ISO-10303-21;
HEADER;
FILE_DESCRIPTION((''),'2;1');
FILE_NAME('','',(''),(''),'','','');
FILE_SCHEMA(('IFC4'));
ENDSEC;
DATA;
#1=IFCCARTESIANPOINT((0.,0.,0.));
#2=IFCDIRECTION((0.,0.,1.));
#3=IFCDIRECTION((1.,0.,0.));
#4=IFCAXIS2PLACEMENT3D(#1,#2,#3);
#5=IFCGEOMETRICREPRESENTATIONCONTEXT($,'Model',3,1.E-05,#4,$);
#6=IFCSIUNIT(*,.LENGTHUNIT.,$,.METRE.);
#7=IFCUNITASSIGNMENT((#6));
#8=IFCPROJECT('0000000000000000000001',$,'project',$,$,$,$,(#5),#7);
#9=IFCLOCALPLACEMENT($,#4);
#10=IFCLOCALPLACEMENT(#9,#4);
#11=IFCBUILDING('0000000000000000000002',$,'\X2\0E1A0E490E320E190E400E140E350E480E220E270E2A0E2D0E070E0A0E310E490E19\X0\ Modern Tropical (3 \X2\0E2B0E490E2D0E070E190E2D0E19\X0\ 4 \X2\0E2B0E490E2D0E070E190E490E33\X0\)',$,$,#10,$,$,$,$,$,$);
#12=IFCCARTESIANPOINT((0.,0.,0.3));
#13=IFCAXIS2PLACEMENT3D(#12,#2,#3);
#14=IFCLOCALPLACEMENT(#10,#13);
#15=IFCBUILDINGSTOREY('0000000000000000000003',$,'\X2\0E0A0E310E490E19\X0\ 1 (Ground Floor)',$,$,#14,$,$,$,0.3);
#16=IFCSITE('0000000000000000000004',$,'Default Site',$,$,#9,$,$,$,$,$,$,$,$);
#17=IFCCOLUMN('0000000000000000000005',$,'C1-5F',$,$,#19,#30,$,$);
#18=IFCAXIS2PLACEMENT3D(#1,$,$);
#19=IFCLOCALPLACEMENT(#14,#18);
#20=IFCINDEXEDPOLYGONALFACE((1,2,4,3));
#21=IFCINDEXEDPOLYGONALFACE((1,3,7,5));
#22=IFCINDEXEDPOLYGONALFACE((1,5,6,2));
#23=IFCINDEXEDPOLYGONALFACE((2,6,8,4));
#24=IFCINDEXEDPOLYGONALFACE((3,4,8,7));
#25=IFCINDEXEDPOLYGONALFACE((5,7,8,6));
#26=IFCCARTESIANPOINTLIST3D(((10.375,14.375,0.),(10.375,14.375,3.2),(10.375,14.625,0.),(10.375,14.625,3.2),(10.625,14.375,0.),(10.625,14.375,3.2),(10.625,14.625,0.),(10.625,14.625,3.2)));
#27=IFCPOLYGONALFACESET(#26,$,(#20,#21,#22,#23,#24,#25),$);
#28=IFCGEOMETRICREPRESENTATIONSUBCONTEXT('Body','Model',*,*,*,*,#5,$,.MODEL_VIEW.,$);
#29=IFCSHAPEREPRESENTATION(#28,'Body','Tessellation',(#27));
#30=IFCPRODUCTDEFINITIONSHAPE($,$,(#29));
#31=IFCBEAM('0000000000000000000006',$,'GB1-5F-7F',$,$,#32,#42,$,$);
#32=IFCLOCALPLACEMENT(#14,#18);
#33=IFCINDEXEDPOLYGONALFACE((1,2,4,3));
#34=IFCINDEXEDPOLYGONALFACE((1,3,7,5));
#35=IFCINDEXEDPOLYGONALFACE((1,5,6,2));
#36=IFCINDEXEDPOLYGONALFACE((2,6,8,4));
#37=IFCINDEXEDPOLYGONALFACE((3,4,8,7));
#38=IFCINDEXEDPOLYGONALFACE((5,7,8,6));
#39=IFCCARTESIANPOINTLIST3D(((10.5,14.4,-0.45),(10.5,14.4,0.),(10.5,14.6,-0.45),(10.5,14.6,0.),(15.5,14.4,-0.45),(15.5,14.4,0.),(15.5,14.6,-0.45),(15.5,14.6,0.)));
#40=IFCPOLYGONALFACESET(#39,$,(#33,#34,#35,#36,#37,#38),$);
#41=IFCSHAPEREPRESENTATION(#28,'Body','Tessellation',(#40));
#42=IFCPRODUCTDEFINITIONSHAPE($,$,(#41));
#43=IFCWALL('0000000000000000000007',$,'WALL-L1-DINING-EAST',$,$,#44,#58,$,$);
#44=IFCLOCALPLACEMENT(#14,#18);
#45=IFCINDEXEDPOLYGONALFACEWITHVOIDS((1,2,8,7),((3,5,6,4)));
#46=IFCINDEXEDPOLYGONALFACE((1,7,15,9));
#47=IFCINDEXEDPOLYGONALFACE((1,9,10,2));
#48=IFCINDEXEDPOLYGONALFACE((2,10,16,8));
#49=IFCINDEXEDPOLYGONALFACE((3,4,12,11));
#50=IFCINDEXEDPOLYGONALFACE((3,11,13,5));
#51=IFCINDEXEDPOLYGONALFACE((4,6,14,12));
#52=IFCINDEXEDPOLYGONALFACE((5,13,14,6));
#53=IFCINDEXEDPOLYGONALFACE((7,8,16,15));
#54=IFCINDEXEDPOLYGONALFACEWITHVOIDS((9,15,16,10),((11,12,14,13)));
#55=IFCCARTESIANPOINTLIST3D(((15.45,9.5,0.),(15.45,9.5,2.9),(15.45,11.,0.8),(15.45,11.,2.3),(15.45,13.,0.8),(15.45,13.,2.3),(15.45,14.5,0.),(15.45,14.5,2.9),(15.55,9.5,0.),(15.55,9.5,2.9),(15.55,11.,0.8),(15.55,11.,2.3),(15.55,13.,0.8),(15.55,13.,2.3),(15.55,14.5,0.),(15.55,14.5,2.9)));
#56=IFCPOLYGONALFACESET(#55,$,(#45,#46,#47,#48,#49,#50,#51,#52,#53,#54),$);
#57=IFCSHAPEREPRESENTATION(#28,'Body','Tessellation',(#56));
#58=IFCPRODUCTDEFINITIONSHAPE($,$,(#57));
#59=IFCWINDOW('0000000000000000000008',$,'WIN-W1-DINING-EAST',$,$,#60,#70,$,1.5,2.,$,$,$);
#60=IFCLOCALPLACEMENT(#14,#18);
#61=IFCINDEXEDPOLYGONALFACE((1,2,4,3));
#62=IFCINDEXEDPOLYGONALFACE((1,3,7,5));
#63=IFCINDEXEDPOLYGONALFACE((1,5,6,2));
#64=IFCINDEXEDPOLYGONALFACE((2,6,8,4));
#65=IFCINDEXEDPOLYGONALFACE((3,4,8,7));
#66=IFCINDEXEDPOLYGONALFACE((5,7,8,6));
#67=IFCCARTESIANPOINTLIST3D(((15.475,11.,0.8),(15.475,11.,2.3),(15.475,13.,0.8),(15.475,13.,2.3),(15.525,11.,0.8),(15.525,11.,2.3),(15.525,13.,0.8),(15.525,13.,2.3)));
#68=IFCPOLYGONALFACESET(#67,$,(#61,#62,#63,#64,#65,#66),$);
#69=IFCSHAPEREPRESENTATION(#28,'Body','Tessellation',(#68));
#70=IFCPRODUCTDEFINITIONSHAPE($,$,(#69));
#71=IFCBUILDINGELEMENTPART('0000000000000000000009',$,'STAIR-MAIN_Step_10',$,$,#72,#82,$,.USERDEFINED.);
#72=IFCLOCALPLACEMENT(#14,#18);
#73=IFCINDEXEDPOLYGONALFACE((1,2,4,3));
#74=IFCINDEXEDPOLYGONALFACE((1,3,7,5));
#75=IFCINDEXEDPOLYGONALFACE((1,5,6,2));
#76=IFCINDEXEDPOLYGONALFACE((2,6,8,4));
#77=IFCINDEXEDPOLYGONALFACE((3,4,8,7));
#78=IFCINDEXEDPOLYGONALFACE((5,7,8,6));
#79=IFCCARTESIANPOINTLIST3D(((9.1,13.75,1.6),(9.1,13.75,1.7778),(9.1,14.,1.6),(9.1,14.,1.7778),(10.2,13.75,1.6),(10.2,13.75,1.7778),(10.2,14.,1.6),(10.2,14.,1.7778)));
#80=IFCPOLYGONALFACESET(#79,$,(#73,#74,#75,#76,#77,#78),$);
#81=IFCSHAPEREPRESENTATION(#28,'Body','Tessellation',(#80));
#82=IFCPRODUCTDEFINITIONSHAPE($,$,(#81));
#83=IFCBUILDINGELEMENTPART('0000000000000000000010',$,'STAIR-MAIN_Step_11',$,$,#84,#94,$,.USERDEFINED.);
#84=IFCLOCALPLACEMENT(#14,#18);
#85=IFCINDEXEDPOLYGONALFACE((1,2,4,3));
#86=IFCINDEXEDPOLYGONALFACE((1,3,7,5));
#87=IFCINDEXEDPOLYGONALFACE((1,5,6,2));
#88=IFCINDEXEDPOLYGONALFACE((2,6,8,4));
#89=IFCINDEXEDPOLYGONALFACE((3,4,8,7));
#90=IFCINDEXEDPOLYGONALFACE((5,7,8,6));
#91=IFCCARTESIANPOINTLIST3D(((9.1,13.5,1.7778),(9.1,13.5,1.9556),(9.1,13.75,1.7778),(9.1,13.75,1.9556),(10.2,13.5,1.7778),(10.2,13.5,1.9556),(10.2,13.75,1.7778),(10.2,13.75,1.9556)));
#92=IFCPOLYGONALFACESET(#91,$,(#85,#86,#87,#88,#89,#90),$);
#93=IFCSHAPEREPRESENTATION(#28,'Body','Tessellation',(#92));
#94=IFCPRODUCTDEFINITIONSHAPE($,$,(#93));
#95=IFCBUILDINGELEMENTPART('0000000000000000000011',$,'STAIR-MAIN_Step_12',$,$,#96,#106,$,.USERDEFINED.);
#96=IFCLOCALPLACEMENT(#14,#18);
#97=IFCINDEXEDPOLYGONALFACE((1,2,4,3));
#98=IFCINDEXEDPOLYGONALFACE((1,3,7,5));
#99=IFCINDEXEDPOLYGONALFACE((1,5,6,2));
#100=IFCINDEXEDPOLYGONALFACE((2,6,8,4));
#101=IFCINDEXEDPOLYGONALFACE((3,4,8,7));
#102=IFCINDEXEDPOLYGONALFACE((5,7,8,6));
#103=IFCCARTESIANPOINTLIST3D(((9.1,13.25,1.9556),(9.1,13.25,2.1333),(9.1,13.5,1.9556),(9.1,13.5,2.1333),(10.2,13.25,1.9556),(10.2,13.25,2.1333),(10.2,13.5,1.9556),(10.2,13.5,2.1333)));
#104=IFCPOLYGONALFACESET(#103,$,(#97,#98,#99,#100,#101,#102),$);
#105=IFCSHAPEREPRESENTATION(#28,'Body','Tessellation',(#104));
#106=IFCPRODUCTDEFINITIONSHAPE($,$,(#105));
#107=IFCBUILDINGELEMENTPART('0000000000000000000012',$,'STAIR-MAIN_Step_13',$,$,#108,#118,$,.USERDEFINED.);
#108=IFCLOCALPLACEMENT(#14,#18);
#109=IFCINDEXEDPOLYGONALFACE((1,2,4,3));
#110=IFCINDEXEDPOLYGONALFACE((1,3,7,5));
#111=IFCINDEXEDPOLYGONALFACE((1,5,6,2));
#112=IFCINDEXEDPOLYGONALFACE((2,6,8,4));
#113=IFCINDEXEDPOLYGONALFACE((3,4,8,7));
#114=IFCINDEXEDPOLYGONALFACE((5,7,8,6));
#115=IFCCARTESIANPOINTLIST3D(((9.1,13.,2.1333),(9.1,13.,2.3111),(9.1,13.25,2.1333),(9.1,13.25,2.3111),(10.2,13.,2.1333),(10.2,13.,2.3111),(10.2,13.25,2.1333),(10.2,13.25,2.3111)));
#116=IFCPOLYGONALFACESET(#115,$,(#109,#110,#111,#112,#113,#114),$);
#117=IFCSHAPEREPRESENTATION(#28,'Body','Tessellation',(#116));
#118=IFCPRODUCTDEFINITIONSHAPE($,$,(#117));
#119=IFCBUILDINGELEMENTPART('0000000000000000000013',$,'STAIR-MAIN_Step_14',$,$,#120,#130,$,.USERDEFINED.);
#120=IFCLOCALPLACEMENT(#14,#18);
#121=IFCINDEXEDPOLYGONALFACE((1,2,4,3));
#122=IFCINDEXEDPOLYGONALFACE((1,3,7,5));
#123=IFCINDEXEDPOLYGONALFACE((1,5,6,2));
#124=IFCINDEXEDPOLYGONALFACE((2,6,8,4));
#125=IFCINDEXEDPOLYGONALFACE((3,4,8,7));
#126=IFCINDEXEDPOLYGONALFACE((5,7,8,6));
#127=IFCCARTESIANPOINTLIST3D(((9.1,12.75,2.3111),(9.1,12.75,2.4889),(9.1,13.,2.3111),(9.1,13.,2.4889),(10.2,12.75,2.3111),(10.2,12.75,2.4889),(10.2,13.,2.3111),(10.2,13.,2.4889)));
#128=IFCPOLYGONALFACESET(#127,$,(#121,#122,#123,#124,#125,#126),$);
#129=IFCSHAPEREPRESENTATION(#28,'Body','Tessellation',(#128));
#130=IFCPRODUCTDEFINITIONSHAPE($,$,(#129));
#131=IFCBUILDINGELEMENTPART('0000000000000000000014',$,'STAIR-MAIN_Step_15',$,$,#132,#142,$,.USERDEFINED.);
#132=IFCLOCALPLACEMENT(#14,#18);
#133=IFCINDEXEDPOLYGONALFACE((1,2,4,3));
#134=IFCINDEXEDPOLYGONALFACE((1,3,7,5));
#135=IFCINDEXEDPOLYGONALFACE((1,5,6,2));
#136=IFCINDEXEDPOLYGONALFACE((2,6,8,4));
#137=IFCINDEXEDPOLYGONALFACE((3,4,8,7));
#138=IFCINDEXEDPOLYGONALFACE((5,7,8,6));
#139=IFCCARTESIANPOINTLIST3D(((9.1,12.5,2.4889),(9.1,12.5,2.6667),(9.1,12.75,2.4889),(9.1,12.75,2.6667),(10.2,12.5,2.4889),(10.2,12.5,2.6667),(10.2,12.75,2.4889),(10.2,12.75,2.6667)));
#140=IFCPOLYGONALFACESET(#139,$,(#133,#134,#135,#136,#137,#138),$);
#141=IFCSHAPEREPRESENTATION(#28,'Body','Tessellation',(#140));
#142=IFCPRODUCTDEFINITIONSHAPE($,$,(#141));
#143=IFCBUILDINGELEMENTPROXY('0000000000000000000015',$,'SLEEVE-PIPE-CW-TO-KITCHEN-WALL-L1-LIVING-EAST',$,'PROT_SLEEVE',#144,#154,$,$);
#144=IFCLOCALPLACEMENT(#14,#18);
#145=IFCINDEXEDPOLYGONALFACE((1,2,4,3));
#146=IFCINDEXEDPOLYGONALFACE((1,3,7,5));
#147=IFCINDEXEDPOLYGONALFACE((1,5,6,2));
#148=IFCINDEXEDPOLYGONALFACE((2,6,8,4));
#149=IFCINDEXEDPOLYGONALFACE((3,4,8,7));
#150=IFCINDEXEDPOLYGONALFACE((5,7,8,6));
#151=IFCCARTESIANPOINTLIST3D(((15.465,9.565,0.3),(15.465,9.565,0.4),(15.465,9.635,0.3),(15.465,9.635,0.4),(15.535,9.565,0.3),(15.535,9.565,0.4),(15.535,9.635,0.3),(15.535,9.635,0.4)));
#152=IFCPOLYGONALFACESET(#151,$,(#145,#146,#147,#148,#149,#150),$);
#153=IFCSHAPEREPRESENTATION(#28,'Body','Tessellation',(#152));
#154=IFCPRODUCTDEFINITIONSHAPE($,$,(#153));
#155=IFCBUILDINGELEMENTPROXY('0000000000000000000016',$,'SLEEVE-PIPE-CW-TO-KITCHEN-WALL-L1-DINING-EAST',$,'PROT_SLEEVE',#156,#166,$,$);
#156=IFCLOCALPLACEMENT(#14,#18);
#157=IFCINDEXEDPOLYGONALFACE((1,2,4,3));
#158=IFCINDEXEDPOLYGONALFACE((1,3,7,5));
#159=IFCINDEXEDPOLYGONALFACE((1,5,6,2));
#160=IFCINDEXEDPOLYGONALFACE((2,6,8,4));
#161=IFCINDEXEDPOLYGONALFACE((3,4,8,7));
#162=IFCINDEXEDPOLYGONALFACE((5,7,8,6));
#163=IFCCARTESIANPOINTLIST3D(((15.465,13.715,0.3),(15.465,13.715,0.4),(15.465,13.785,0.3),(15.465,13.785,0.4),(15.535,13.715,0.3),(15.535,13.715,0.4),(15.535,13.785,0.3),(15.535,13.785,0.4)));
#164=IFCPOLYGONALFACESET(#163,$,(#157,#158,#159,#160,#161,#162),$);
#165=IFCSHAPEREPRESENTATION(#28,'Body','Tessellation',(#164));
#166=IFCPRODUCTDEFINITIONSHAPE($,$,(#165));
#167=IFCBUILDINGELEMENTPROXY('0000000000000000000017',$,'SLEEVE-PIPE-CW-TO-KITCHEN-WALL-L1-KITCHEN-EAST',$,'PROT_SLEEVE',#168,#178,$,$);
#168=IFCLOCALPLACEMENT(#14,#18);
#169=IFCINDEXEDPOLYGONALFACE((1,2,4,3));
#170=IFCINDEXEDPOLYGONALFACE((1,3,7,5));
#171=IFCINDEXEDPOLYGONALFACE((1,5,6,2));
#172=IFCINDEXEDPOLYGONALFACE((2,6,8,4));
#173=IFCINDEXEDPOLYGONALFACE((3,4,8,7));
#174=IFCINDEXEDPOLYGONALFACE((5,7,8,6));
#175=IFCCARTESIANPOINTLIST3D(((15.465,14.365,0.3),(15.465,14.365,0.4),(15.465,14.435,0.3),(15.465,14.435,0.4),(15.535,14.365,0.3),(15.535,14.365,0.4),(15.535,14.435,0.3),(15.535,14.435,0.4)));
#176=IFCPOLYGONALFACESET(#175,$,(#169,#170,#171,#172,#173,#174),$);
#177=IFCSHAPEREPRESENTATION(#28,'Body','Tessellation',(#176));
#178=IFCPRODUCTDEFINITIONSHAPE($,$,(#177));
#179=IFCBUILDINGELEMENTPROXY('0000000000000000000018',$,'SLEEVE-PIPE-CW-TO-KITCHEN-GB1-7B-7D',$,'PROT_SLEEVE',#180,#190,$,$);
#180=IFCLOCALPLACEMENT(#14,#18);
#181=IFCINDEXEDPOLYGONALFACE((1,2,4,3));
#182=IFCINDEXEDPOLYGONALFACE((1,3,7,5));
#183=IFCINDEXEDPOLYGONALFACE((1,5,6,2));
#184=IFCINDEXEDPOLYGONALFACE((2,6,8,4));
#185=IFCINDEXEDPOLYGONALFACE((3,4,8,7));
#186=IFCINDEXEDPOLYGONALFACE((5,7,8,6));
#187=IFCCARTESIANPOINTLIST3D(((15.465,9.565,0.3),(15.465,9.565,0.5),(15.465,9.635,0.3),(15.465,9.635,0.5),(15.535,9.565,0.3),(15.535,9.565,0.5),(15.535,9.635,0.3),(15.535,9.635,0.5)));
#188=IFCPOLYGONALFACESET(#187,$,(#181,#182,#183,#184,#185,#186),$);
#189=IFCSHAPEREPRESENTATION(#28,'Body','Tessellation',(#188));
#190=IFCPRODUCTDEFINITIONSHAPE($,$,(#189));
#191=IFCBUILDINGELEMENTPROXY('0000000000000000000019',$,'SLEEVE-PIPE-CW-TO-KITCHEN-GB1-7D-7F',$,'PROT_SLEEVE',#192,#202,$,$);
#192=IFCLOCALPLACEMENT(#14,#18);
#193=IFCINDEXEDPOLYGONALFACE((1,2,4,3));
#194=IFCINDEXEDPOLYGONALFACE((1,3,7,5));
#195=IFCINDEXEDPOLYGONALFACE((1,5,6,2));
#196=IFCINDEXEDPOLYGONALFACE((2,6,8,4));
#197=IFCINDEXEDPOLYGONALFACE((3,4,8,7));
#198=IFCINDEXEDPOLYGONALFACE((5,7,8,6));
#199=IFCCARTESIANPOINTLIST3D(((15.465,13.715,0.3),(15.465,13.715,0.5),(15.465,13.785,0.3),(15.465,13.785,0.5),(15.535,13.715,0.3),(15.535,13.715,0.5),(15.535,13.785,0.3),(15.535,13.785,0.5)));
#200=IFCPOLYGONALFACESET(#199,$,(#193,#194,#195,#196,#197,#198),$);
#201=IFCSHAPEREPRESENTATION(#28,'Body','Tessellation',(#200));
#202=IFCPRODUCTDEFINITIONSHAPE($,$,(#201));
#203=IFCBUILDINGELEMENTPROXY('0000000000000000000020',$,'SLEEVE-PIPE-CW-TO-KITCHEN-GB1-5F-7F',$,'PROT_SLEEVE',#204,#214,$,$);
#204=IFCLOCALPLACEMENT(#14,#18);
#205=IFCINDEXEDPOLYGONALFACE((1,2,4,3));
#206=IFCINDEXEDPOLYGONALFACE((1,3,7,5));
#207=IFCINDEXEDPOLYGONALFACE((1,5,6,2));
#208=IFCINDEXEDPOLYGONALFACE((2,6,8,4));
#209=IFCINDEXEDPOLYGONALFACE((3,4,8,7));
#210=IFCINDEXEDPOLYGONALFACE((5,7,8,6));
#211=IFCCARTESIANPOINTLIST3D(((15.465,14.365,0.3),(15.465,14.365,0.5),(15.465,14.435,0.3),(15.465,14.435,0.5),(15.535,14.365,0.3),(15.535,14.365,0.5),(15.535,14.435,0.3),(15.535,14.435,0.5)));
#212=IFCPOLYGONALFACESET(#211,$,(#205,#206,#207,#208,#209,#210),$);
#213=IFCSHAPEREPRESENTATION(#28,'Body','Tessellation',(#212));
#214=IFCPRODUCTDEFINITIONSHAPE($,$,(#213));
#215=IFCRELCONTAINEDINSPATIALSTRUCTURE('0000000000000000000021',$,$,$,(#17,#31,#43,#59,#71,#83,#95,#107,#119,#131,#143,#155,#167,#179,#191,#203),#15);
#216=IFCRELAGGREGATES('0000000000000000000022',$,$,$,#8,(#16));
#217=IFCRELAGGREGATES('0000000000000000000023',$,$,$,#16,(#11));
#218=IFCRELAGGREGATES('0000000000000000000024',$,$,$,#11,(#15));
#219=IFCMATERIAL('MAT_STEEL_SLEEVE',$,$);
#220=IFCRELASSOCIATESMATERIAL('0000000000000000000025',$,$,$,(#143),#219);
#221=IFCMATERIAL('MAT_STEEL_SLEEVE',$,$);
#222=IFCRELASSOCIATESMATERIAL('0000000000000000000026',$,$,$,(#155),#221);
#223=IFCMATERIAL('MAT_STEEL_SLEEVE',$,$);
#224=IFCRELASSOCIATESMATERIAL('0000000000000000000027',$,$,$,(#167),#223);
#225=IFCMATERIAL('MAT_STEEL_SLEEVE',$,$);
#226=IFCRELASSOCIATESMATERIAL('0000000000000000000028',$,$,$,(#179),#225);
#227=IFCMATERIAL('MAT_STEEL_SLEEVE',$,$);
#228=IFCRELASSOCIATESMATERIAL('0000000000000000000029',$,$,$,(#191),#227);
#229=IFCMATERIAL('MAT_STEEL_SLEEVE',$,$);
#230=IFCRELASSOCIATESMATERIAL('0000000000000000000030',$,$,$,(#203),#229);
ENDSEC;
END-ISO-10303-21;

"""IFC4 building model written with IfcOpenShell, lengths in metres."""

from ifc_helpers import new_model, si_unit, frame, origin_with_axes, origin_2d, place, context, subcontext, project, spatial, rectangle, extrude, material, element, fill, save


model = new_model("IFC4")

# Units and contexts
model_context = context("Model", 3, precision=1e-05, world=origin_with_axes())
body_context = subcontext(model_context, "Body", "Model", "MODEL_VIEW")
ifc_project = project(units=[si_unit("LENGTHUNIT", "METRE")], contexts=[model_context])

# Site, building, storey
site_placement = place(None, origin_with_axes())
site = spatial("IfcSite", under=ifc_project, at=site_placement, Name="Default Site")
building_placement = place(site_placement, origin_with_axes())
building = spatial("IfcBuilding", under=site, at=building_placement, Name="บ้านเดี่ยวสองชั้น Modern Tropical (3 ห้องนอน 4 ห้องน้ำ)")
storey_placement = place(building_placement, frame((0.0, 0.0, 0.3), z_axis=(0.0, 0.0, 1.0), x_axis=(1.0, 0.0, 0.0)))
storey = spatial("IfcBuildingStorey", under=building, at=storey_placement, Name="ชั้น 1 (Ground Floor)", Elevation=0.3)

# Column
column_placement = place(storey_placement, frame((10.5, 14.5, 0.0), z_axis=(0.0, 0.0, 1.0), x_axis=(1.0, 0.0, 0.0)))
element("IfcColumn", 1, at=column_placement, inside=storey, Name="C1-5F", context=body_context, shape_type="SweptSolid", body=[
    extrude(rectangle(XDim=0.25, YDim=0.25, at=origin_2d()), origin_with_axes(), (0.0, 0.0, 1.0), 3.2),
])

# Beam
beam_placement = place(storey_placement, frame((10.5, 14.5, -0.225), z_axis=(1.0, 0.0, 0.0), x_axis=(0.0, 1.0, 0.0)))
element("IfcBeam", 2, at=beam_placement, inside=storey, Name="GB1-5F-7F", context=body_context, shape_type="SweptSolid", body=[
    extrude(rectangle(XDim=0.2, YDim=0.45, at=origin_2d()), origin_with_axes(), (0.0, 0.0, 1.0), 5.0),
])

# Wall, opening, window
wall_placement = place(storey_placement, frame((15.5, 12.0, 0.0), z_axis=(0.0, 0.0, 1.0), x_axis=(0.0, 1.0, 0.0)))
wall = element("IfcWall", 3, at=wall_placement, inside=storey, Name="WALL-L1-DINING-EAST", context=body_context, shape_type="SweptSolid", body=[
    extrude(rectangle(XDim=5.0, YDim=0.1, at=origin_2d()), origin_with_axes(), (0.0, 0.0, 1.0), 2.9),
])
opening_placement = place(wall_placement, frame((0.0, 0.0, 0.8), z_axis=(0.0, 0.0, 1.0), x_axis=(1.0, 0.0, 0.0)))
opening = element("IfcOpeningElement", 4, at=opening_placement, cuts=wall, context=body_context, shape_type="SweptSolid", body=[
    extrude(rectangle(XDim=2.0, YDim=0.12, at=origin_2d()), origin_with_axes(), (0.0, 0.0, 1.0), 1.5),
])
window_placement = place(opening_placement, origin_with_axes())
window = element("IfcWindow", 5, at=window_placement, inside=storey, Name="WIN-W1-DINING-EAST", OverallHeight=1.5, OverallWidth=2.0, context=body_context, shape_type="SweptSolid", body=[
    extrude(rectangle(XDim=2.0, YDim=0.05, at=origin_2d()), origin_with_axes(), (0.0, 0.0, 1.0), 1.5),
])
fill(opening, window)

# Building element parts
for number, where, z_axis, x_axis, name in (
    (6, (9.65, 13.875, 1.6), (0.0, 0.0, 1.0), (1.0, 0.0, 0.0), "STAIR-MAIN_Step_10"),
    (7, (9.65, 13.625, 1.7778), (0.0, 0.0, 1.0), (1.0, 0.0, 0.0), "STAIR-MAIN_Step_11"),
    (8, (9.65, 13.375, 1.9556), (0.0, 0.0, 1.0), (1.0, 0.0, 0.0), "STAIR-MAIN_Step_12"),
    (9, (9.65, 13.125, 2.1333), (0.0, 0.0, 1.0), (1.0, 0.0, 0.0), "STAIR-MAIN_Step_13"),
    (10, (9.65, 12.875, 2.3111), (0.0, 0.0, 1.0), (1.0, 0.0, 0.0), "STAIR-MAIN_Step_14"),
    (11, (9.65, 12.625, 2.4889), (0.0, 0.0, 1.0), (1.0, 0.0, 0.0), "STAIR-MAIN_Step_15"),
):
    element("IfcBuildingElementPart", number, at=place(storey_placement, frame(where, z_axis=z_axis, x_axis=x_axis)), inside=storey, Name=name, PredefinedType="USERDEFINED", context=body_context, shape_type="SweptSolid", body=[
        extrude(rectangle(XDim=1.1, YDim=0.25, at=origin_2d()), origin_with_axes(), (0.0, 0.0, 1.0), 0.1778),
    ])

# Building element proxies
ifc_material_1 = material(Name="MAT_STEEL_SLEEVE")
proxy_1_placement = place(storey_placement, frame((15.5, 9.6, 0.3), z_axis=(0.0, 0.0, 1.0), x_axis=(1.0, 0.0, 0.0)))
element("IfcBuildingElementProxy", 12, at=proxy_1_placement, inside=storey, material=ifc_material_1, Name="SLEEVE-PIPE-CW-TO-KITCHEN-WALL-L1-LIVING-EAST", ObjectType="PROT_SLEEVE", context=body_context, shape_type="SweptSolid", body=[
    extrude(rectangle(XDim=0.07, YDim=0.07, at=origin_2d()), origin_with_axes(), (0.0, 0.0, 1.0), 0.1),
])
ifc_material_2 = material(Name="MAT_STEEL_SLEEVE")
proxy_2_placement = place(storey_placement, frame((15.5, 13.75, 0.3), z_axis=(0.0, 0.0, 1.0), x_axis=(1.0, 0.0, 0.0)))
element("IfcBuildingElementProxy", 13, at=proxy_2_placement, inside=storey, material=ifc_material_2, Name="SLEEVE-PIPE-CW-TO-KITCHEN-WALL-L1-DINING-EAST", ObjectType="PROT_SLEEVE", context=body_context, shape_type="SweptSolid", body=[
    extrude(rectangle(XDim=0.07, YDim=0.07, at=origin_2d()), origin_with_axes(), (0.0, 0.0, 1.0), 0.1),
])
ifc_material_3 = material(Name="MAT_STEEL_SLEEVE")
proxy_3_placement = place(storey_placement, frame((15.5, 14.4, 0.3), z_axis=(0.0, 0.0, 1.0), x_axis=(1.0, 0.0, 0.0)))
element("IfcBuildingElementProxy", 14, at=proxy_3_placement, inside=storey, material=ifc_material_3, Name="SLEEVE-PIPE-CW-TO-KITCHEN-WALL-L1-KITCHEN-EAST", ObjectType="PROT_SLEEVE", context=body_context, shape_type="SweptSolid", body=[
    extrude(rectangle(XDim=0.07, YDim=0.07, at=origin_2d()), origin_with_axes(), (0.0, 0.0, 1.0), 0.1),
])
ifc_material_4 = material(Name="MAT_STEEL_SLEEVE")
proxy_4_placement = place(storey_placement, frame((15.5, 9.6, 0.3), z_axis=(0.0, 0.0, 1.0), x_axis=(1.0, 0.0, 0.0)))
element("IfcBuildingElementProxy", 15, at=proxy_4_placement, inside=storey, material=ifc_material_4, Name="SLEEVE-PIPE-CW-TO-KITCHEN-GB1-7B-7D", ObjectType="PROT_SLEEVE", context=body_context, shape_type="SweptSolid", body=[
    extrude(rectangle(XDim=0.07, YDim=0.07, at=origin_2d()), origin_with_axes(), (0.0, 0.0, 1.0), 0.2),
])
ifc_material_5 = material(Name="MAT_STEEL_SLEEVE")
proxy_5_placement = place(storey_placement, frame((15.5, 13.75, 0.3), z_axis=(0.0, 0.0, 1.0), x_axis=(1.0, 0.0, 0.0)))
element("IfcBuildingElementProxy", 16, at=proxy_5_placement, inside=storey, material=ifc_material_5, Name="SLEEVE-PIPE-CW-TO-KITCHEN-GB1-7D-7F", ObjectType="PROT_SLEEVE", context=body_context, shape_type="SweptSolid", body=[
    extrude(rectangle(XDim=0.07, YDim=0.07, at=origin_2d()), origin_with_axes(), (0.0, 0.0, 1.0), 0.2),
])
ifc_material_6 = material(Name="MAT_STEEL_SLEEVE")
proxy_6_placement = place(storey_placement, frame((15.5, 14.4, 0.3), z_axis=(0.0, 0.0, 1.0), x_axis=(1.0, 0.0, 0.0)))
element("IfcBuildingElementProxy", 17, at=proxy_6_placement, inside=storey, material=ifc_material_6, Name="SLEEVE-PIPE-CW-TO-KITCHEN-GB1-5F-7F", ObjectType="PROT_SLEEVE", context=body_context, shape_type="SweptSolid", body=[
    extrude(rectangle(XDim=0.07, YDim=0.07, at=origin_2d()), origin_with_axes(), (0.0, 0.0, 1.0), 0.2),
])

save(model, "model.ifc")
